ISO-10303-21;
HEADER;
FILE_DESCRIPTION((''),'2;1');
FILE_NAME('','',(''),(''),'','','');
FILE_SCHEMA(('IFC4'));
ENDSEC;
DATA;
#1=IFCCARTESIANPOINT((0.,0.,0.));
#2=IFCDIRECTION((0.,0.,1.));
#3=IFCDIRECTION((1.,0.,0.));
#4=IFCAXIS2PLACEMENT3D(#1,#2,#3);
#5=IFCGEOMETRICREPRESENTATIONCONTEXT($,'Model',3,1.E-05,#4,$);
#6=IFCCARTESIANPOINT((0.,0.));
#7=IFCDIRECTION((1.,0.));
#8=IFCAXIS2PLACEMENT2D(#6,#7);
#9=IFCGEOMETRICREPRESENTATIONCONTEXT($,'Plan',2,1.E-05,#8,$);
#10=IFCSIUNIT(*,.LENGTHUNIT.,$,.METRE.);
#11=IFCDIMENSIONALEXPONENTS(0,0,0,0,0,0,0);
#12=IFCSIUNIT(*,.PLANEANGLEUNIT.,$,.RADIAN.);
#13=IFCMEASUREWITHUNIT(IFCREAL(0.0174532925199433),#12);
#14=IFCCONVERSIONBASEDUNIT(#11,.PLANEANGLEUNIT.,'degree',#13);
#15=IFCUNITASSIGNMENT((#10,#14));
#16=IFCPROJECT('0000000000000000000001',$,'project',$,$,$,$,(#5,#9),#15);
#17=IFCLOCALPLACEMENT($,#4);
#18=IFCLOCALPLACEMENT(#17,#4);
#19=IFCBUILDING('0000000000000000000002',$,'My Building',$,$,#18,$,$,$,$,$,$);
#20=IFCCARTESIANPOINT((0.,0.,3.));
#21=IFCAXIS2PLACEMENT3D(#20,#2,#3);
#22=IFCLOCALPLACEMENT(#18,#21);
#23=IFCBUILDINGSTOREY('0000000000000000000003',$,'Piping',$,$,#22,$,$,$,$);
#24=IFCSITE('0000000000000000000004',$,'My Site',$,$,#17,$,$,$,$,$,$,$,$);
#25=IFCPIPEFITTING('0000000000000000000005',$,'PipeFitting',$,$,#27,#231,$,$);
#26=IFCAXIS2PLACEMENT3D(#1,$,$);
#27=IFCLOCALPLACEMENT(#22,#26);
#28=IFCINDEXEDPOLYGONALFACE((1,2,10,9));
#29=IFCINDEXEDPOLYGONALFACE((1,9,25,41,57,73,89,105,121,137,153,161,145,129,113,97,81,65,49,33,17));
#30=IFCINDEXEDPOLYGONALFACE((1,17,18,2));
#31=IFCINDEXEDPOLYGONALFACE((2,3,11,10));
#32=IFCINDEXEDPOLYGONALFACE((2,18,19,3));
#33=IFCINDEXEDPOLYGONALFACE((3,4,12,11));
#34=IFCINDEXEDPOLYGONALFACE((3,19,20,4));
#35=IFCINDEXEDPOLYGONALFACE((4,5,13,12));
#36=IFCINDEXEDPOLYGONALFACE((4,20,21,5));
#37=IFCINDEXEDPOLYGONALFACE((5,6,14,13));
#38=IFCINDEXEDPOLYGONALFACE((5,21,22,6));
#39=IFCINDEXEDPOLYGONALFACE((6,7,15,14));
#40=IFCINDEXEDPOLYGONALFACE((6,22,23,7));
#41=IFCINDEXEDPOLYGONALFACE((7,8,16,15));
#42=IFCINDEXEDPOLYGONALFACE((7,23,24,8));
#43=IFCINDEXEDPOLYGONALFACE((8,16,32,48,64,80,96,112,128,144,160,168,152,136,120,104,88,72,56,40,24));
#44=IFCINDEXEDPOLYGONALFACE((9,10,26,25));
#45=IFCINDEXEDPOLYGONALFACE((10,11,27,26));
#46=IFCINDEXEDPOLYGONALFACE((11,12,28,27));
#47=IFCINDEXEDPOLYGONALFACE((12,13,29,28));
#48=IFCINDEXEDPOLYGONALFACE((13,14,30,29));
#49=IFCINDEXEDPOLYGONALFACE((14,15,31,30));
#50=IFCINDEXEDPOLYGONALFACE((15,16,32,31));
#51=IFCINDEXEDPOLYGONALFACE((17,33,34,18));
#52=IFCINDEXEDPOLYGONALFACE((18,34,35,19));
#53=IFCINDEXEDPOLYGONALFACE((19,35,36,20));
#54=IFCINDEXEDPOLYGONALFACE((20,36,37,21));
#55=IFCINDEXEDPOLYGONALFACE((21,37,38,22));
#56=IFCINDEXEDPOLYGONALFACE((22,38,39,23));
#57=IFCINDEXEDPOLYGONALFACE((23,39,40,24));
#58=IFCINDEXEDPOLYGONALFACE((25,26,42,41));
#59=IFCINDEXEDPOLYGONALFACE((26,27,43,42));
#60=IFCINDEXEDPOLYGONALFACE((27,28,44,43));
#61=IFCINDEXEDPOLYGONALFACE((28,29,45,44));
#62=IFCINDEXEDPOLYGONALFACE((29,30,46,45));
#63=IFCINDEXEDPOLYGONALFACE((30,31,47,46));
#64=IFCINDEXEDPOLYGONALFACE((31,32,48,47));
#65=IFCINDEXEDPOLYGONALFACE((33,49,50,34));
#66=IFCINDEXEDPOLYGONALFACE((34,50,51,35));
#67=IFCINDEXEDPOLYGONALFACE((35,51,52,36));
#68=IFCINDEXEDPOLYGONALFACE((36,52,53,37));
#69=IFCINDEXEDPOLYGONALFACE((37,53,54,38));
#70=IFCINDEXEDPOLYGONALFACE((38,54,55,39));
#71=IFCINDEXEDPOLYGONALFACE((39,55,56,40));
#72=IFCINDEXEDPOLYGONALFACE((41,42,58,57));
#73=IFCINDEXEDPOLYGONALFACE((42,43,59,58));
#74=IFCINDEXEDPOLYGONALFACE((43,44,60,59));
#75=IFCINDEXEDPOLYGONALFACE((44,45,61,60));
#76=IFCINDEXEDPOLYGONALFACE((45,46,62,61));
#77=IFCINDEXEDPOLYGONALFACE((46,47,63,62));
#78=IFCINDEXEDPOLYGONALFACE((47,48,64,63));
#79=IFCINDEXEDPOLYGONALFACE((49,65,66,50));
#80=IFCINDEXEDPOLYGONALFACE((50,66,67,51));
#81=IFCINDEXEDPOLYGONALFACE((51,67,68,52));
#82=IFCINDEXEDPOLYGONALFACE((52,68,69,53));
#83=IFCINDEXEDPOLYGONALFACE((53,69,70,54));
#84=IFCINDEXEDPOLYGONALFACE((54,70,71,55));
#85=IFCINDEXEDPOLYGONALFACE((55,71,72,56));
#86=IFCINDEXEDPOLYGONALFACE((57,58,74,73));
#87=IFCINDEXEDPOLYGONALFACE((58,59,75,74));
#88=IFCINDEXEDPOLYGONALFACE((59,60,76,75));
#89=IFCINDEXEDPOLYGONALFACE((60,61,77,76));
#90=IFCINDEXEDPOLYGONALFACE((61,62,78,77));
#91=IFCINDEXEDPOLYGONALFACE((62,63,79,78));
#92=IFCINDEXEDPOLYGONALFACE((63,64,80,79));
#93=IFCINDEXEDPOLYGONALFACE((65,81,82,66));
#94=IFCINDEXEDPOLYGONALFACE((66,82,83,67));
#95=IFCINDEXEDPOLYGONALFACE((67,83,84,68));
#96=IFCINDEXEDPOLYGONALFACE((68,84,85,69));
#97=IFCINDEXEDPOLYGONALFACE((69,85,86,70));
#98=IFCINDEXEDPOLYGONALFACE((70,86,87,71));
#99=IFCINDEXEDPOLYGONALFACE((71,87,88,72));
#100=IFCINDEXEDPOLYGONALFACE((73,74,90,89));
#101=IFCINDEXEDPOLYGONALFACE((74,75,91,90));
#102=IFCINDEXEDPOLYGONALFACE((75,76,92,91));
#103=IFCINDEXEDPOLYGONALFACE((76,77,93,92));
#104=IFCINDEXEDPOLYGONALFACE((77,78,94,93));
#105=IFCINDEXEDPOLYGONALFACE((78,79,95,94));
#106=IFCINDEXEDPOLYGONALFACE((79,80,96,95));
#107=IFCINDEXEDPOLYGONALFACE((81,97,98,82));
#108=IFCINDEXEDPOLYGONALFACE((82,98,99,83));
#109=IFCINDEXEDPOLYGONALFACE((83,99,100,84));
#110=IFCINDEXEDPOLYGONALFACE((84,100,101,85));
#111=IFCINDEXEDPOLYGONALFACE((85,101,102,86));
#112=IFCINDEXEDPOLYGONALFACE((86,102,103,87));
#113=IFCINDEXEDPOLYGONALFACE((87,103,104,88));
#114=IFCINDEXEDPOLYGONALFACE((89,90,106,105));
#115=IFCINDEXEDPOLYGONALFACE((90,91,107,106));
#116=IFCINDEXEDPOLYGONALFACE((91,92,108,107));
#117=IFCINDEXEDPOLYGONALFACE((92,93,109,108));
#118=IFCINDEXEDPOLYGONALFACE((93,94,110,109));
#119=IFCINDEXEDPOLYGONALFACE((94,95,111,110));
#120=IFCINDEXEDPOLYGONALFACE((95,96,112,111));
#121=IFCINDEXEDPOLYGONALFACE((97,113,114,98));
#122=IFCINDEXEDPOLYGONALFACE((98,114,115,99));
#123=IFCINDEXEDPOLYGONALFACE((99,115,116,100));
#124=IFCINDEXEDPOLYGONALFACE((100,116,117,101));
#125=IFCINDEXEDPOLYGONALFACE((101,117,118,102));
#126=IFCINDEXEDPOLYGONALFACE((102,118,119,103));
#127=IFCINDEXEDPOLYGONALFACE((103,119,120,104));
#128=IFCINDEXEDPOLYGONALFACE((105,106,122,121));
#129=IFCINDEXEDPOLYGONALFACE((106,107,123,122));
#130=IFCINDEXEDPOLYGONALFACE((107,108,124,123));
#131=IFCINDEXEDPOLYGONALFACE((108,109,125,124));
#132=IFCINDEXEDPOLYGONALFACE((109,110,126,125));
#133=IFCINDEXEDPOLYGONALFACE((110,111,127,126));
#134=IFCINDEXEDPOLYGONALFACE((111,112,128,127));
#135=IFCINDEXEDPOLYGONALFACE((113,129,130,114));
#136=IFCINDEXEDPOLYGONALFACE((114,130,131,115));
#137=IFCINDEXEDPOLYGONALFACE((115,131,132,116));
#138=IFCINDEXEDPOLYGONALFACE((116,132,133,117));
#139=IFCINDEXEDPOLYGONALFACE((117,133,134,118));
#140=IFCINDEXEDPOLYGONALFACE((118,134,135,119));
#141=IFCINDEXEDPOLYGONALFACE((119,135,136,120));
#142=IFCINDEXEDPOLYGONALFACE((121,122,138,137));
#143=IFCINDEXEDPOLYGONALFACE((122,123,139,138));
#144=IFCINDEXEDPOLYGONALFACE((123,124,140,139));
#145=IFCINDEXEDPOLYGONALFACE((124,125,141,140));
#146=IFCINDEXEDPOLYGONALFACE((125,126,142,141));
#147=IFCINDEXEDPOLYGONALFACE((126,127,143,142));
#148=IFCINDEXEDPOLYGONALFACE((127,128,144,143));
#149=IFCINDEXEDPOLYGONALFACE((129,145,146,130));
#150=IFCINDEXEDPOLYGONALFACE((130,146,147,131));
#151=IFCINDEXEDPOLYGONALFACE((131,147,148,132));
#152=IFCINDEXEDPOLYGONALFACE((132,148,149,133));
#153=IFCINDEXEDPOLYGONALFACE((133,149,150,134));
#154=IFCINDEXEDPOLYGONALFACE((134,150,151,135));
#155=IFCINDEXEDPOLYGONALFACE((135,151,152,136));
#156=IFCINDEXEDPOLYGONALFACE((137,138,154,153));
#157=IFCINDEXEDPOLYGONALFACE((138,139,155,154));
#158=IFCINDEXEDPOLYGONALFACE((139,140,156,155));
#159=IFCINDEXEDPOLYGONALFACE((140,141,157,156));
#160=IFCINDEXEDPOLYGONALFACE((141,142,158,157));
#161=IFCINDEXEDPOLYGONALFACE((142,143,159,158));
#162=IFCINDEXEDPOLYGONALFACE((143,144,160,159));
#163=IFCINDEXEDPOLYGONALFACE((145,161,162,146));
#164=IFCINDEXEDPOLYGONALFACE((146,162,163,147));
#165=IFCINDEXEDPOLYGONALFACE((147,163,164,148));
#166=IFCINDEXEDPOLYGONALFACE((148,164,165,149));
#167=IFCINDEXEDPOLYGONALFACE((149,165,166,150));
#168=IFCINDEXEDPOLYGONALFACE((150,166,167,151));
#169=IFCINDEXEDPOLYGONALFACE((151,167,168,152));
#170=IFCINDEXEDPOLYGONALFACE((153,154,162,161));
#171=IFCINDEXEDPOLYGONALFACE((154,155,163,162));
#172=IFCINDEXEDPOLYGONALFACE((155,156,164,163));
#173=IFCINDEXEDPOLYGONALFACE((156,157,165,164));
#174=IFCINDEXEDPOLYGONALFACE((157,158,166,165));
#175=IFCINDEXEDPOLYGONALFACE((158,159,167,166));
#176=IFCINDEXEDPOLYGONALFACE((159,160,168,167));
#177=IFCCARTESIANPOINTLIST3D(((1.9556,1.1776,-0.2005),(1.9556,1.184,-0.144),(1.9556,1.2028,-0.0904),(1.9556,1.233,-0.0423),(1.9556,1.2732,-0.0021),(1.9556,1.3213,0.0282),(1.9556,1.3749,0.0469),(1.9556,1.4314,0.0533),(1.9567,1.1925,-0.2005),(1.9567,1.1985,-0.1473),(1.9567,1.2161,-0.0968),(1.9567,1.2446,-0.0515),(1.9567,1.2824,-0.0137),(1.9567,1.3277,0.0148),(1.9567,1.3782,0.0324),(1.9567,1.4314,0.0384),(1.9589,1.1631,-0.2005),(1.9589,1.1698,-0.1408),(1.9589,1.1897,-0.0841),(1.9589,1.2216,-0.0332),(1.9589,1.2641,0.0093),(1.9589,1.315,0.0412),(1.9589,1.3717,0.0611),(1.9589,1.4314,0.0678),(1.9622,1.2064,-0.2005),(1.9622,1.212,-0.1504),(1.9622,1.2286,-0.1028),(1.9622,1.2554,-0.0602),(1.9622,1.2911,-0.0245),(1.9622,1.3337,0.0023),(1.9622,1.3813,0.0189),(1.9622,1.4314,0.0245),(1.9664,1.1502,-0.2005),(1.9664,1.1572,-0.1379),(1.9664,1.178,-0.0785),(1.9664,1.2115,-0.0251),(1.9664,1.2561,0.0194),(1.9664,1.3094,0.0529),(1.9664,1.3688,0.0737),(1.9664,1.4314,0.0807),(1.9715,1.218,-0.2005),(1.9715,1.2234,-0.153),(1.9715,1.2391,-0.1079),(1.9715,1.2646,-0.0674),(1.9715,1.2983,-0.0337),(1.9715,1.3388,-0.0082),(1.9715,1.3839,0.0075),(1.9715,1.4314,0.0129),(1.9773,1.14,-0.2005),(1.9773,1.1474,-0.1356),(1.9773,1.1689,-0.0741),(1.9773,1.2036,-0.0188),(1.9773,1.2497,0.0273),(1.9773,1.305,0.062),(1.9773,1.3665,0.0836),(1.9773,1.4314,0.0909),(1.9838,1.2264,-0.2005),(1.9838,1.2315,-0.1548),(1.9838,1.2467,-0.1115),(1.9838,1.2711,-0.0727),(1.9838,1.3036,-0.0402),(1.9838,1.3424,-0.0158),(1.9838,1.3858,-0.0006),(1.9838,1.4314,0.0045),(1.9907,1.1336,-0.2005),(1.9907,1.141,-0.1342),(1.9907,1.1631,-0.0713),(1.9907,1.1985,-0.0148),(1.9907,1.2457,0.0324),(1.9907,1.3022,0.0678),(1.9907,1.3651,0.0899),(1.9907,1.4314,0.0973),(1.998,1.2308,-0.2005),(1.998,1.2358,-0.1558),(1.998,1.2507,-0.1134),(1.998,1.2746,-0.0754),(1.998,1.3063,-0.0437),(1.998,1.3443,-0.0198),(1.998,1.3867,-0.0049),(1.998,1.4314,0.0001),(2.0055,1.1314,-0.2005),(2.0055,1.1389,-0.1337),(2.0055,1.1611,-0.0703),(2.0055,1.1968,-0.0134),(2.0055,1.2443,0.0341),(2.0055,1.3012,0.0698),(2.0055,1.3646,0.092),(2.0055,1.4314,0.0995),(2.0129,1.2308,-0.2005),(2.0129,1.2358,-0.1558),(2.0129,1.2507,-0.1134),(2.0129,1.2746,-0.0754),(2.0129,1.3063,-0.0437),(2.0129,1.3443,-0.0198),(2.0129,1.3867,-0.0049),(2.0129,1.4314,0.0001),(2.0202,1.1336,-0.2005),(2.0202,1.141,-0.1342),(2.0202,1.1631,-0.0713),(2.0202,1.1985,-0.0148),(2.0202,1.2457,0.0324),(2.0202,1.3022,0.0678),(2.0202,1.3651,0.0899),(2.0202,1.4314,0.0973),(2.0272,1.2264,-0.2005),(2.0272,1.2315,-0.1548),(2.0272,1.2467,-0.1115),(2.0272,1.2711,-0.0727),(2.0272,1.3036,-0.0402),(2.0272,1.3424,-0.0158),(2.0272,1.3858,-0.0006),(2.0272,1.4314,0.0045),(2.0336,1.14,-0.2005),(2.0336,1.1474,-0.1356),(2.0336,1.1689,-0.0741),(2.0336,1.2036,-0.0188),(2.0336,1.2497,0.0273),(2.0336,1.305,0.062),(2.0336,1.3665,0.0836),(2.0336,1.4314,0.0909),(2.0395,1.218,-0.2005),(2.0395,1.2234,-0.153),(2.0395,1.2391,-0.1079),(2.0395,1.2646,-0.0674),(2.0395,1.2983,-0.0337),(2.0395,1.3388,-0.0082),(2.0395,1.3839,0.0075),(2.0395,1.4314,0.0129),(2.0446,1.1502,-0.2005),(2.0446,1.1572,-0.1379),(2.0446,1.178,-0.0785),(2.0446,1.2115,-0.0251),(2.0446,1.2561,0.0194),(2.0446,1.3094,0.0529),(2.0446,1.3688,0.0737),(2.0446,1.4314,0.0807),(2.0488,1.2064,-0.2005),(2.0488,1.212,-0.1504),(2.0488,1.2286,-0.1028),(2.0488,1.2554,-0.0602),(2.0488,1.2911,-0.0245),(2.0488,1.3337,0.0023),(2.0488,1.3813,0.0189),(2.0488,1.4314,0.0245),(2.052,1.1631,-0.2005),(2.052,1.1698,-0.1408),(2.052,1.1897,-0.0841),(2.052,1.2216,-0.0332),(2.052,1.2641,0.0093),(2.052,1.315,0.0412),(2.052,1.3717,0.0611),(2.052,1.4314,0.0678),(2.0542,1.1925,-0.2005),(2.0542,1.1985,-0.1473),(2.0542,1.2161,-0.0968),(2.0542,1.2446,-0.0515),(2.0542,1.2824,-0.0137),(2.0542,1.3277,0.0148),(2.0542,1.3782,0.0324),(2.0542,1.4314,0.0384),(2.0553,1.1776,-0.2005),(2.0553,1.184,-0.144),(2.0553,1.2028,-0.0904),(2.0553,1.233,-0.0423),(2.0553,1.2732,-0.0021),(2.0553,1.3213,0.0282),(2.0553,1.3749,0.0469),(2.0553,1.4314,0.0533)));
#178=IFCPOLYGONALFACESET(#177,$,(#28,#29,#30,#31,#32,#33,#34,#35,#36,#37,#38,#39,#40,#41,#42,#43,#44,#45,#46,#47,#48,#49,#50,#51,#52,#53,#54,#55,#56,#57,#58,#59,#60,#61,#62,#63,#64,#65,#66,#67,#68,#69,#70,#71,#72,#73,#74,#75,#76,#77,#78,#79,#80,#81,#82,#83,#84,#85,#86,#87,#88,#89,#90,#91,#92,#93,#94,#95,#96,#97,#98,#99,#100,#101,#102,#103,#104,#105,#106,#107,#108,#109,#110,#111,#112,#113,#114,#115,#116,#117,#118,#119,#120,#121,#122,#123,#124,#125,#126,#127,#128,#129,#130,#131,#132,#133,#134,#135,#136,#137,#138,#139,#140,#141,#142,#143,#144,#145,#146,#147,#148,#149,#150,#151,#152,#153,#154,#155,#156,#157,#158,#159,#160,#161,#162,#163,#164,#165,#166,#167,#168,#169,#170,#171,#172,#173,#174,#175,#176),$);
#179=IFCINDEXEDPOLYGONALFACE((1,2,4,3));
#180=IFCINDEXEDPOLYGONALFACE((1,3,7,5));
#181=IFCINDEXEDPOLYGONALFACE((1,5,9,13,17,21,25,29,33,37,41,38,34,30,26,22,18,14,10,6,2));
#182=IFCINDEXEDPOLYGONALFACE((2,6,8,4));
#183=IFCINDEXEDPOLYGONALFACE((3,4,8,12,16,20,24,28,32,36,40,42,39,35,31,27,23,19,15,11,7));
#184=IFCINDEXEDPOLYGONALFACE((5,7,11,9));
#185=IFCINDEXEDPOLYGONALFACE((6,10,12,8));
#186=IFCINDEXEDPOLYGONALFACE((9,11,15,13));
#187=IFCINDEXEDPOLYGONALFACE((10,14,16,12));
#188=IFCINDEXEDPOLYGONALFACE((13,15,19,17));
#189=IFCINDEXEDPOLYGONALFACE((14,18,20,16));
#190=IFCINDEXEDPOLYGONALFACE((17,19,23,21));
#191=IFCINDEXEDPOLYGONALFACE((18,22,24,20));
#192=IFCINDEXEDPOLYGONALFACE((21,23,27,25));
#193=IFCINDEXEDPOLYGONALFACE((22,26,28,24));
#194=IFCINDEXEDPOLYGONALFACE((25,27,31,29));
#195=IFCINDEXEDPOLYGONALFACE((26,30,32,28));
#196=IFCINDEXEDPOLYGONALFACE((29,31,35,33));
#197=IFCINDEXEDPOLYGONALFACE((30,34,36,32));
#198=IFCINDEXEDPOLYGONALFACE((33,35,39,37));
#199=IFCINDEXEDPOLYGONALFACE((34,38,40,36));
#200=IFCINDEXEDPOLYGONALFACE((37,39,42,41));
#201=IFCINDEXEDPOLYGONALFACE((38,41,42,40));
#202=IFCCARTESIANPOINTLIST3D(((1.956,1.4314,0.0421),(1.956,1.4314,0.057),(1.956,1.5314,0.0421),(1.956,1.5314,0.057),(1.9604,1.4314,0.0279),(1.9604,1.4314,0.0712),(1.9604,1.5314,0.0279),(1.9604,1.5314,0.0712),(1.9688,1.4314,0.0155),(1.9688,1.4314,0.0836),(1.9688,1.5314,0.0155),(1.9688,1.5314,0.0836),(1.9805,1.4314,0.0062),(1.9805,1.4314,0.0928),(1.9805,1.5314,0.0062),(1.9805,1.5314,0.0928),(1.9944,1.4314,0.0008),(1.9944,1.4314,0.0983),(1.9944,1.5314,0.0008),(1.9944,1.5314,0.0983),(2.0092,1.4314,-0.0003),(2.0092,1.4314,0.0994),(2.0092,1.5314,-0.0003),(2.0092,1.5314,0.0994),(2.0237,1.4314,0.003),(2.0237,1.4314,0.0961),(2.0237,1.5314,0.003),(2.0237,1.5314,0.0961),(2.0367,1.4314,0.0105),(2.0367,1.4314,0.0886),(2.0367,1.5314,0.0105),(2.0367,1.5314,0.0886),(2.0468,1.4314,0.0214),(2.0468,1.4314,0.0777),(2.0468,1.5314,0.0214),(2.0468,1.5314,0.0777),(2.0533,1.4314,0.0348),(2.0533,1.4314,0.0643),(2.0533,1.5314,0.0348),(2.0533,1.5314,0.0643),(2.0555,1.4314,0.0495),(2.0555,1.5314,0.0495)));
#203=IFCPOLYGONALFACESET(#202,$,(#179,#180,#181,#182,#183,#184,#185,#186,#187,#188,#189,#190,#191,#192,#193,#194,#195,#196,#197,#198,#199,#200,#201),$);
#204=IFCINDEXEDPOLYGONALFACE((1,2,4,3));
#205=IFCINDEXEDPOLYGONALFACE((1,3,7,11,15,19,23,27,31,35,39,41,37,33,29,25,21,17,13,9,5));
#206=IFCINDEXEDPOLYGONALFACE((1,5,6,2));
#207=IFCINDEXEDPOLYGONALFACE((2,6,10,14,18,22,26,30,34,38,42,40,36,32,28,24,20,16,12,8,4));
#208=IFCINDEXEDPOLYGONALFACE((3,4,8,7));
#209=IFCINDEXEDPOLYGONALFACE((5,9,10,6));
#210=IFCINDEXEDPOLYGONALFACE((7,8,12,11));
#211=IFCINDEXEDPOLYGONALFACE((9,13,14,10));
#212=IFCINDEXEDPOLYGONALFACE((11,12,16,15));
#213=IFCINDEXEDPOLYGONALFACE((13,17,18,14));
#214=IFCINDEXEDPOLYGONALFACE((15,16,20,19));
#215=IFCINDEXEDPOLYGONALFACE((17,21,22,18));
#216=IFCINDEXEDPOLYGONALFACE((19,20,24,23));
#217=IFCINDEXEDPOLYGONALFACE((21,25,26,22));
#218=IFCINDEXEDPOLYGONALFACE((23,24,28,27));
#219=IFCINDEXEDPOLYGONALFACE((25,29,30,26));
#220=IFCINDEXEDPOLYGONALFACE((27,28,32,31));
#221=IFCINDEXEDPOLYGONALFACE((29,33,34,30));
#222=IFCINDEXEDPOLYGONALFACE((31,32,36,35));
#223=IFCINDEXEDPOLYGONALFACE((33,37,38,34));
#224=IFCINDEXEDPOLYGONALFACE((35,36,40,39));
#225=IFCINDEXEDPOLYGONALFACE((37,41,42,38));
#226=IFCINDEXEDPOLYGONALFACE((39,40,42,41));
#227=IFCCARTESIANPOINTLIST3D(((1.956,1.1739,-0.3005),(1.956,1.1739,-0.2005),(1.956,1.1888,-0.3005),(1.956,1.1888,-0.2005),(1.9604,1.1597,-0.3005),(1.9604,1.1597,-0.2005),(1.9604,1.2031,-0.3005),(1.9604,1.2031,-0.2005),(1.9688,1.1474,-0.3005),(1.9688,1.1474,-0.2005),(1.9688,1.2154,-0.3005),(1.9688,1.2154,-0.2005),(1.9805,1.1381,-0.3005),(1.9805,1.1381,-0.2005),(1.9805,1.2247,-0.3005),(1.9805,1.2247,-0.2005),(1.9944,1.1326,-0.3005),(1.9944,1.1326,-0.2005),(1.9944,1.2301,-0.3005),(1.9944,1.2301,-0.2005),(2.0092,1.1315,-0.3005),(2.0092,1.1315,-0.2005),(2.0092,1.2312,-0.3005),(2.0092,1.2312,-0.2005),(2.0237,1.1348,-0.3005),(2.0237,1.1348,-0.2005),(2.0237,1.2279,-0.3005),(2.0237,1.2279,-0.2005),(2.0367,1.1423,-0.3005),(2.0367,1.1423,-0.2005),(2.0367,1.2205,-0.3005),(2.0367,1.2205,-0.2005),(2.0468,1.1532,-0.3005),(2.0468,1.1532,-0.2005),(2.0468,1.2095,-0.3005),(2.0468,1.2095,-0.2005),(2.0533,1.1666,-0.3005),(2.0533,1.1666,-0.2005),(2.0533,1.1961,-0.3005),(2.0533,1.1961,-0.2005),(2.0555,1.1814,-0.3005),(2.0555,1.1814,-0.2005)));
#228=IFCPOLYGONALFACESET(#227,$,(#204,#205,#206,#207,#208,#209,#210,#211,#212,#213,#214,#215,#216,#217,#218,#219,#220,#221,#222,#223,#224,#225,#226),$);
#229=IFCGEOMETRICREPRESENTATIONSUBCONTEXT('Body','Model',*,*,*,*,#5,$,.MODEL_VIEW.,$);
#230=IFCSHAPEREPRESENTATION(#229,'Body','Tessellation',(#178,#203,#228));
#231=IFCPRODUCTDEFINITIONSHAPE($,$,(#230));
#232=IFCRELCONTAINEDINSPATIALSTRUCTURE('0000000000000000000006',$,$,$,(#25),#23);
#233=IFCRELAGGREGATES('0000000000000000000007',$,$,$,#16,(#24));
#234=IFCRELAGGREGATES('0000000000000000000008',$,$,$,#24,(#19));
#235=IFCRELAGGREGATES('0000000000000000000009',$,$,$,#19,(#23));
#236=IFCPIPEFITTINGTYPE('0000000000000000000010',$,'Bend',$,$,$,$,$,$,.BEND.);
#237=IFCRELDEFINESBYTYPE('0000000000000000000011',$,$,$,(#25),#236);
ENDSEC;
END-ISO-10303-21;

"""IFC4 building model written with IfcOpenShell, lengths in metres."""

from ifc_helpers import new_model, entity, si_unit, converted_unit, frame, origin_with_axes, origin_2d_with_axis, place, context, subcontext, project, spatial, circle, extrude, source, transform, mapped, type_object, type_shapes, element, save


model = new_model("IFC4")

# Units and contexts
model_context = context("Model", 3, precision=1e-05, world=origin_with_axes())
plan_context = context("Plan", 2, precision=1e-05, world=origin_2d_with_axis())
body_context = subcontext(model_context, "Body", "Model", "MODEL_VIEW")
ifc_project = project(units=[si_unit("LENGTHUNIT", "METRE"), converted_unit("PLANEANGLEUNIT", "degree", entity("IfcReal", 0.0174532925199433), si_unit("PLANEANGLEUNIT", "RADIAN"), dimensions=[0, 0, 0, 0, 0, 0, 0])], contexts=[model_context, plan_context])

# Site, building, storey
site_placement = place(None, origin_with_axes())
site = spatial("IfcSite", under=ifc_project, at=site_placement, Name="My Site")
building_placement = place(site_placement, origin_with_axes())
building = spatial("IfcBuilding", under=site, at=building_placement, Name="My Building")
storey_placement = place(building_placement, frame((0.0, 0.0, 3.0), z_axis=(0.0, 0.0, 1.0), x_axis=(1.0, 0.0, 0.0)))
storey = spatial("IfcBuildingStorey", under=building, at=storey_placement, Name="Piping")

# Pipe fitting
pipe_fitting_type = type_object("IfcPipeFittingType", Name="Bend", PredefinedType="BEND")
shared_shape = source(origin_with_axes(), body_context, "Body", "SolidModel", [
    entity("IfcSweptDiskSolid", entity("IfcIndexedPolyCurve", entity("IfcCartesianPointList3D", [[0.0, 0.0, 0.1], [0.0, -0.0732, 0.2768], [0.0, -0.25, 0.35]]), [entity("IfcArcIndex", [1, 2, 3])]), 0.05),
    extrude(circle(Radius=0.05), origin_with_axes(), (0.0, 0.0, 1.0), 0.1),
    extrude(circle(Radius=0.05), frame((0.0, -0.25, 0.35), z_axis=(0.0, -1.0, 0.0), x_axis=(1.0, 0.0, 0.0)), (0.0, 0.0, 1.0), 0.1),
])
type_shapes(pipe_fitting_type, [shared_shape])
for number, where, z_axis, x_axis, name in (
    (1, (2.0055, 1.5314, 0.0495), (0.0, -1.0, 0.0), (1.0, 0.0, 0.0), "PipeFitting"),
):
    element("IfcPipeFitting", number, at=place(storey_placement, frame(where, z_axis=z_axis, x_axis=x_axis)), inside=storey, type_object=pipe_fitting_type, Name=name, context=body_context, shape_type="MappedRepresentation", body=[
        mapped(shared_shape, transform((0.0, 0.0, 0.0), x_axis=(1.0, 0.0, 0.0), y_axis=(0.0, 1.0, 0.0), z_axis=(0.0, 0.0, 1.0), scale=1.0)),
    ])

save(model, "model.ifc")
